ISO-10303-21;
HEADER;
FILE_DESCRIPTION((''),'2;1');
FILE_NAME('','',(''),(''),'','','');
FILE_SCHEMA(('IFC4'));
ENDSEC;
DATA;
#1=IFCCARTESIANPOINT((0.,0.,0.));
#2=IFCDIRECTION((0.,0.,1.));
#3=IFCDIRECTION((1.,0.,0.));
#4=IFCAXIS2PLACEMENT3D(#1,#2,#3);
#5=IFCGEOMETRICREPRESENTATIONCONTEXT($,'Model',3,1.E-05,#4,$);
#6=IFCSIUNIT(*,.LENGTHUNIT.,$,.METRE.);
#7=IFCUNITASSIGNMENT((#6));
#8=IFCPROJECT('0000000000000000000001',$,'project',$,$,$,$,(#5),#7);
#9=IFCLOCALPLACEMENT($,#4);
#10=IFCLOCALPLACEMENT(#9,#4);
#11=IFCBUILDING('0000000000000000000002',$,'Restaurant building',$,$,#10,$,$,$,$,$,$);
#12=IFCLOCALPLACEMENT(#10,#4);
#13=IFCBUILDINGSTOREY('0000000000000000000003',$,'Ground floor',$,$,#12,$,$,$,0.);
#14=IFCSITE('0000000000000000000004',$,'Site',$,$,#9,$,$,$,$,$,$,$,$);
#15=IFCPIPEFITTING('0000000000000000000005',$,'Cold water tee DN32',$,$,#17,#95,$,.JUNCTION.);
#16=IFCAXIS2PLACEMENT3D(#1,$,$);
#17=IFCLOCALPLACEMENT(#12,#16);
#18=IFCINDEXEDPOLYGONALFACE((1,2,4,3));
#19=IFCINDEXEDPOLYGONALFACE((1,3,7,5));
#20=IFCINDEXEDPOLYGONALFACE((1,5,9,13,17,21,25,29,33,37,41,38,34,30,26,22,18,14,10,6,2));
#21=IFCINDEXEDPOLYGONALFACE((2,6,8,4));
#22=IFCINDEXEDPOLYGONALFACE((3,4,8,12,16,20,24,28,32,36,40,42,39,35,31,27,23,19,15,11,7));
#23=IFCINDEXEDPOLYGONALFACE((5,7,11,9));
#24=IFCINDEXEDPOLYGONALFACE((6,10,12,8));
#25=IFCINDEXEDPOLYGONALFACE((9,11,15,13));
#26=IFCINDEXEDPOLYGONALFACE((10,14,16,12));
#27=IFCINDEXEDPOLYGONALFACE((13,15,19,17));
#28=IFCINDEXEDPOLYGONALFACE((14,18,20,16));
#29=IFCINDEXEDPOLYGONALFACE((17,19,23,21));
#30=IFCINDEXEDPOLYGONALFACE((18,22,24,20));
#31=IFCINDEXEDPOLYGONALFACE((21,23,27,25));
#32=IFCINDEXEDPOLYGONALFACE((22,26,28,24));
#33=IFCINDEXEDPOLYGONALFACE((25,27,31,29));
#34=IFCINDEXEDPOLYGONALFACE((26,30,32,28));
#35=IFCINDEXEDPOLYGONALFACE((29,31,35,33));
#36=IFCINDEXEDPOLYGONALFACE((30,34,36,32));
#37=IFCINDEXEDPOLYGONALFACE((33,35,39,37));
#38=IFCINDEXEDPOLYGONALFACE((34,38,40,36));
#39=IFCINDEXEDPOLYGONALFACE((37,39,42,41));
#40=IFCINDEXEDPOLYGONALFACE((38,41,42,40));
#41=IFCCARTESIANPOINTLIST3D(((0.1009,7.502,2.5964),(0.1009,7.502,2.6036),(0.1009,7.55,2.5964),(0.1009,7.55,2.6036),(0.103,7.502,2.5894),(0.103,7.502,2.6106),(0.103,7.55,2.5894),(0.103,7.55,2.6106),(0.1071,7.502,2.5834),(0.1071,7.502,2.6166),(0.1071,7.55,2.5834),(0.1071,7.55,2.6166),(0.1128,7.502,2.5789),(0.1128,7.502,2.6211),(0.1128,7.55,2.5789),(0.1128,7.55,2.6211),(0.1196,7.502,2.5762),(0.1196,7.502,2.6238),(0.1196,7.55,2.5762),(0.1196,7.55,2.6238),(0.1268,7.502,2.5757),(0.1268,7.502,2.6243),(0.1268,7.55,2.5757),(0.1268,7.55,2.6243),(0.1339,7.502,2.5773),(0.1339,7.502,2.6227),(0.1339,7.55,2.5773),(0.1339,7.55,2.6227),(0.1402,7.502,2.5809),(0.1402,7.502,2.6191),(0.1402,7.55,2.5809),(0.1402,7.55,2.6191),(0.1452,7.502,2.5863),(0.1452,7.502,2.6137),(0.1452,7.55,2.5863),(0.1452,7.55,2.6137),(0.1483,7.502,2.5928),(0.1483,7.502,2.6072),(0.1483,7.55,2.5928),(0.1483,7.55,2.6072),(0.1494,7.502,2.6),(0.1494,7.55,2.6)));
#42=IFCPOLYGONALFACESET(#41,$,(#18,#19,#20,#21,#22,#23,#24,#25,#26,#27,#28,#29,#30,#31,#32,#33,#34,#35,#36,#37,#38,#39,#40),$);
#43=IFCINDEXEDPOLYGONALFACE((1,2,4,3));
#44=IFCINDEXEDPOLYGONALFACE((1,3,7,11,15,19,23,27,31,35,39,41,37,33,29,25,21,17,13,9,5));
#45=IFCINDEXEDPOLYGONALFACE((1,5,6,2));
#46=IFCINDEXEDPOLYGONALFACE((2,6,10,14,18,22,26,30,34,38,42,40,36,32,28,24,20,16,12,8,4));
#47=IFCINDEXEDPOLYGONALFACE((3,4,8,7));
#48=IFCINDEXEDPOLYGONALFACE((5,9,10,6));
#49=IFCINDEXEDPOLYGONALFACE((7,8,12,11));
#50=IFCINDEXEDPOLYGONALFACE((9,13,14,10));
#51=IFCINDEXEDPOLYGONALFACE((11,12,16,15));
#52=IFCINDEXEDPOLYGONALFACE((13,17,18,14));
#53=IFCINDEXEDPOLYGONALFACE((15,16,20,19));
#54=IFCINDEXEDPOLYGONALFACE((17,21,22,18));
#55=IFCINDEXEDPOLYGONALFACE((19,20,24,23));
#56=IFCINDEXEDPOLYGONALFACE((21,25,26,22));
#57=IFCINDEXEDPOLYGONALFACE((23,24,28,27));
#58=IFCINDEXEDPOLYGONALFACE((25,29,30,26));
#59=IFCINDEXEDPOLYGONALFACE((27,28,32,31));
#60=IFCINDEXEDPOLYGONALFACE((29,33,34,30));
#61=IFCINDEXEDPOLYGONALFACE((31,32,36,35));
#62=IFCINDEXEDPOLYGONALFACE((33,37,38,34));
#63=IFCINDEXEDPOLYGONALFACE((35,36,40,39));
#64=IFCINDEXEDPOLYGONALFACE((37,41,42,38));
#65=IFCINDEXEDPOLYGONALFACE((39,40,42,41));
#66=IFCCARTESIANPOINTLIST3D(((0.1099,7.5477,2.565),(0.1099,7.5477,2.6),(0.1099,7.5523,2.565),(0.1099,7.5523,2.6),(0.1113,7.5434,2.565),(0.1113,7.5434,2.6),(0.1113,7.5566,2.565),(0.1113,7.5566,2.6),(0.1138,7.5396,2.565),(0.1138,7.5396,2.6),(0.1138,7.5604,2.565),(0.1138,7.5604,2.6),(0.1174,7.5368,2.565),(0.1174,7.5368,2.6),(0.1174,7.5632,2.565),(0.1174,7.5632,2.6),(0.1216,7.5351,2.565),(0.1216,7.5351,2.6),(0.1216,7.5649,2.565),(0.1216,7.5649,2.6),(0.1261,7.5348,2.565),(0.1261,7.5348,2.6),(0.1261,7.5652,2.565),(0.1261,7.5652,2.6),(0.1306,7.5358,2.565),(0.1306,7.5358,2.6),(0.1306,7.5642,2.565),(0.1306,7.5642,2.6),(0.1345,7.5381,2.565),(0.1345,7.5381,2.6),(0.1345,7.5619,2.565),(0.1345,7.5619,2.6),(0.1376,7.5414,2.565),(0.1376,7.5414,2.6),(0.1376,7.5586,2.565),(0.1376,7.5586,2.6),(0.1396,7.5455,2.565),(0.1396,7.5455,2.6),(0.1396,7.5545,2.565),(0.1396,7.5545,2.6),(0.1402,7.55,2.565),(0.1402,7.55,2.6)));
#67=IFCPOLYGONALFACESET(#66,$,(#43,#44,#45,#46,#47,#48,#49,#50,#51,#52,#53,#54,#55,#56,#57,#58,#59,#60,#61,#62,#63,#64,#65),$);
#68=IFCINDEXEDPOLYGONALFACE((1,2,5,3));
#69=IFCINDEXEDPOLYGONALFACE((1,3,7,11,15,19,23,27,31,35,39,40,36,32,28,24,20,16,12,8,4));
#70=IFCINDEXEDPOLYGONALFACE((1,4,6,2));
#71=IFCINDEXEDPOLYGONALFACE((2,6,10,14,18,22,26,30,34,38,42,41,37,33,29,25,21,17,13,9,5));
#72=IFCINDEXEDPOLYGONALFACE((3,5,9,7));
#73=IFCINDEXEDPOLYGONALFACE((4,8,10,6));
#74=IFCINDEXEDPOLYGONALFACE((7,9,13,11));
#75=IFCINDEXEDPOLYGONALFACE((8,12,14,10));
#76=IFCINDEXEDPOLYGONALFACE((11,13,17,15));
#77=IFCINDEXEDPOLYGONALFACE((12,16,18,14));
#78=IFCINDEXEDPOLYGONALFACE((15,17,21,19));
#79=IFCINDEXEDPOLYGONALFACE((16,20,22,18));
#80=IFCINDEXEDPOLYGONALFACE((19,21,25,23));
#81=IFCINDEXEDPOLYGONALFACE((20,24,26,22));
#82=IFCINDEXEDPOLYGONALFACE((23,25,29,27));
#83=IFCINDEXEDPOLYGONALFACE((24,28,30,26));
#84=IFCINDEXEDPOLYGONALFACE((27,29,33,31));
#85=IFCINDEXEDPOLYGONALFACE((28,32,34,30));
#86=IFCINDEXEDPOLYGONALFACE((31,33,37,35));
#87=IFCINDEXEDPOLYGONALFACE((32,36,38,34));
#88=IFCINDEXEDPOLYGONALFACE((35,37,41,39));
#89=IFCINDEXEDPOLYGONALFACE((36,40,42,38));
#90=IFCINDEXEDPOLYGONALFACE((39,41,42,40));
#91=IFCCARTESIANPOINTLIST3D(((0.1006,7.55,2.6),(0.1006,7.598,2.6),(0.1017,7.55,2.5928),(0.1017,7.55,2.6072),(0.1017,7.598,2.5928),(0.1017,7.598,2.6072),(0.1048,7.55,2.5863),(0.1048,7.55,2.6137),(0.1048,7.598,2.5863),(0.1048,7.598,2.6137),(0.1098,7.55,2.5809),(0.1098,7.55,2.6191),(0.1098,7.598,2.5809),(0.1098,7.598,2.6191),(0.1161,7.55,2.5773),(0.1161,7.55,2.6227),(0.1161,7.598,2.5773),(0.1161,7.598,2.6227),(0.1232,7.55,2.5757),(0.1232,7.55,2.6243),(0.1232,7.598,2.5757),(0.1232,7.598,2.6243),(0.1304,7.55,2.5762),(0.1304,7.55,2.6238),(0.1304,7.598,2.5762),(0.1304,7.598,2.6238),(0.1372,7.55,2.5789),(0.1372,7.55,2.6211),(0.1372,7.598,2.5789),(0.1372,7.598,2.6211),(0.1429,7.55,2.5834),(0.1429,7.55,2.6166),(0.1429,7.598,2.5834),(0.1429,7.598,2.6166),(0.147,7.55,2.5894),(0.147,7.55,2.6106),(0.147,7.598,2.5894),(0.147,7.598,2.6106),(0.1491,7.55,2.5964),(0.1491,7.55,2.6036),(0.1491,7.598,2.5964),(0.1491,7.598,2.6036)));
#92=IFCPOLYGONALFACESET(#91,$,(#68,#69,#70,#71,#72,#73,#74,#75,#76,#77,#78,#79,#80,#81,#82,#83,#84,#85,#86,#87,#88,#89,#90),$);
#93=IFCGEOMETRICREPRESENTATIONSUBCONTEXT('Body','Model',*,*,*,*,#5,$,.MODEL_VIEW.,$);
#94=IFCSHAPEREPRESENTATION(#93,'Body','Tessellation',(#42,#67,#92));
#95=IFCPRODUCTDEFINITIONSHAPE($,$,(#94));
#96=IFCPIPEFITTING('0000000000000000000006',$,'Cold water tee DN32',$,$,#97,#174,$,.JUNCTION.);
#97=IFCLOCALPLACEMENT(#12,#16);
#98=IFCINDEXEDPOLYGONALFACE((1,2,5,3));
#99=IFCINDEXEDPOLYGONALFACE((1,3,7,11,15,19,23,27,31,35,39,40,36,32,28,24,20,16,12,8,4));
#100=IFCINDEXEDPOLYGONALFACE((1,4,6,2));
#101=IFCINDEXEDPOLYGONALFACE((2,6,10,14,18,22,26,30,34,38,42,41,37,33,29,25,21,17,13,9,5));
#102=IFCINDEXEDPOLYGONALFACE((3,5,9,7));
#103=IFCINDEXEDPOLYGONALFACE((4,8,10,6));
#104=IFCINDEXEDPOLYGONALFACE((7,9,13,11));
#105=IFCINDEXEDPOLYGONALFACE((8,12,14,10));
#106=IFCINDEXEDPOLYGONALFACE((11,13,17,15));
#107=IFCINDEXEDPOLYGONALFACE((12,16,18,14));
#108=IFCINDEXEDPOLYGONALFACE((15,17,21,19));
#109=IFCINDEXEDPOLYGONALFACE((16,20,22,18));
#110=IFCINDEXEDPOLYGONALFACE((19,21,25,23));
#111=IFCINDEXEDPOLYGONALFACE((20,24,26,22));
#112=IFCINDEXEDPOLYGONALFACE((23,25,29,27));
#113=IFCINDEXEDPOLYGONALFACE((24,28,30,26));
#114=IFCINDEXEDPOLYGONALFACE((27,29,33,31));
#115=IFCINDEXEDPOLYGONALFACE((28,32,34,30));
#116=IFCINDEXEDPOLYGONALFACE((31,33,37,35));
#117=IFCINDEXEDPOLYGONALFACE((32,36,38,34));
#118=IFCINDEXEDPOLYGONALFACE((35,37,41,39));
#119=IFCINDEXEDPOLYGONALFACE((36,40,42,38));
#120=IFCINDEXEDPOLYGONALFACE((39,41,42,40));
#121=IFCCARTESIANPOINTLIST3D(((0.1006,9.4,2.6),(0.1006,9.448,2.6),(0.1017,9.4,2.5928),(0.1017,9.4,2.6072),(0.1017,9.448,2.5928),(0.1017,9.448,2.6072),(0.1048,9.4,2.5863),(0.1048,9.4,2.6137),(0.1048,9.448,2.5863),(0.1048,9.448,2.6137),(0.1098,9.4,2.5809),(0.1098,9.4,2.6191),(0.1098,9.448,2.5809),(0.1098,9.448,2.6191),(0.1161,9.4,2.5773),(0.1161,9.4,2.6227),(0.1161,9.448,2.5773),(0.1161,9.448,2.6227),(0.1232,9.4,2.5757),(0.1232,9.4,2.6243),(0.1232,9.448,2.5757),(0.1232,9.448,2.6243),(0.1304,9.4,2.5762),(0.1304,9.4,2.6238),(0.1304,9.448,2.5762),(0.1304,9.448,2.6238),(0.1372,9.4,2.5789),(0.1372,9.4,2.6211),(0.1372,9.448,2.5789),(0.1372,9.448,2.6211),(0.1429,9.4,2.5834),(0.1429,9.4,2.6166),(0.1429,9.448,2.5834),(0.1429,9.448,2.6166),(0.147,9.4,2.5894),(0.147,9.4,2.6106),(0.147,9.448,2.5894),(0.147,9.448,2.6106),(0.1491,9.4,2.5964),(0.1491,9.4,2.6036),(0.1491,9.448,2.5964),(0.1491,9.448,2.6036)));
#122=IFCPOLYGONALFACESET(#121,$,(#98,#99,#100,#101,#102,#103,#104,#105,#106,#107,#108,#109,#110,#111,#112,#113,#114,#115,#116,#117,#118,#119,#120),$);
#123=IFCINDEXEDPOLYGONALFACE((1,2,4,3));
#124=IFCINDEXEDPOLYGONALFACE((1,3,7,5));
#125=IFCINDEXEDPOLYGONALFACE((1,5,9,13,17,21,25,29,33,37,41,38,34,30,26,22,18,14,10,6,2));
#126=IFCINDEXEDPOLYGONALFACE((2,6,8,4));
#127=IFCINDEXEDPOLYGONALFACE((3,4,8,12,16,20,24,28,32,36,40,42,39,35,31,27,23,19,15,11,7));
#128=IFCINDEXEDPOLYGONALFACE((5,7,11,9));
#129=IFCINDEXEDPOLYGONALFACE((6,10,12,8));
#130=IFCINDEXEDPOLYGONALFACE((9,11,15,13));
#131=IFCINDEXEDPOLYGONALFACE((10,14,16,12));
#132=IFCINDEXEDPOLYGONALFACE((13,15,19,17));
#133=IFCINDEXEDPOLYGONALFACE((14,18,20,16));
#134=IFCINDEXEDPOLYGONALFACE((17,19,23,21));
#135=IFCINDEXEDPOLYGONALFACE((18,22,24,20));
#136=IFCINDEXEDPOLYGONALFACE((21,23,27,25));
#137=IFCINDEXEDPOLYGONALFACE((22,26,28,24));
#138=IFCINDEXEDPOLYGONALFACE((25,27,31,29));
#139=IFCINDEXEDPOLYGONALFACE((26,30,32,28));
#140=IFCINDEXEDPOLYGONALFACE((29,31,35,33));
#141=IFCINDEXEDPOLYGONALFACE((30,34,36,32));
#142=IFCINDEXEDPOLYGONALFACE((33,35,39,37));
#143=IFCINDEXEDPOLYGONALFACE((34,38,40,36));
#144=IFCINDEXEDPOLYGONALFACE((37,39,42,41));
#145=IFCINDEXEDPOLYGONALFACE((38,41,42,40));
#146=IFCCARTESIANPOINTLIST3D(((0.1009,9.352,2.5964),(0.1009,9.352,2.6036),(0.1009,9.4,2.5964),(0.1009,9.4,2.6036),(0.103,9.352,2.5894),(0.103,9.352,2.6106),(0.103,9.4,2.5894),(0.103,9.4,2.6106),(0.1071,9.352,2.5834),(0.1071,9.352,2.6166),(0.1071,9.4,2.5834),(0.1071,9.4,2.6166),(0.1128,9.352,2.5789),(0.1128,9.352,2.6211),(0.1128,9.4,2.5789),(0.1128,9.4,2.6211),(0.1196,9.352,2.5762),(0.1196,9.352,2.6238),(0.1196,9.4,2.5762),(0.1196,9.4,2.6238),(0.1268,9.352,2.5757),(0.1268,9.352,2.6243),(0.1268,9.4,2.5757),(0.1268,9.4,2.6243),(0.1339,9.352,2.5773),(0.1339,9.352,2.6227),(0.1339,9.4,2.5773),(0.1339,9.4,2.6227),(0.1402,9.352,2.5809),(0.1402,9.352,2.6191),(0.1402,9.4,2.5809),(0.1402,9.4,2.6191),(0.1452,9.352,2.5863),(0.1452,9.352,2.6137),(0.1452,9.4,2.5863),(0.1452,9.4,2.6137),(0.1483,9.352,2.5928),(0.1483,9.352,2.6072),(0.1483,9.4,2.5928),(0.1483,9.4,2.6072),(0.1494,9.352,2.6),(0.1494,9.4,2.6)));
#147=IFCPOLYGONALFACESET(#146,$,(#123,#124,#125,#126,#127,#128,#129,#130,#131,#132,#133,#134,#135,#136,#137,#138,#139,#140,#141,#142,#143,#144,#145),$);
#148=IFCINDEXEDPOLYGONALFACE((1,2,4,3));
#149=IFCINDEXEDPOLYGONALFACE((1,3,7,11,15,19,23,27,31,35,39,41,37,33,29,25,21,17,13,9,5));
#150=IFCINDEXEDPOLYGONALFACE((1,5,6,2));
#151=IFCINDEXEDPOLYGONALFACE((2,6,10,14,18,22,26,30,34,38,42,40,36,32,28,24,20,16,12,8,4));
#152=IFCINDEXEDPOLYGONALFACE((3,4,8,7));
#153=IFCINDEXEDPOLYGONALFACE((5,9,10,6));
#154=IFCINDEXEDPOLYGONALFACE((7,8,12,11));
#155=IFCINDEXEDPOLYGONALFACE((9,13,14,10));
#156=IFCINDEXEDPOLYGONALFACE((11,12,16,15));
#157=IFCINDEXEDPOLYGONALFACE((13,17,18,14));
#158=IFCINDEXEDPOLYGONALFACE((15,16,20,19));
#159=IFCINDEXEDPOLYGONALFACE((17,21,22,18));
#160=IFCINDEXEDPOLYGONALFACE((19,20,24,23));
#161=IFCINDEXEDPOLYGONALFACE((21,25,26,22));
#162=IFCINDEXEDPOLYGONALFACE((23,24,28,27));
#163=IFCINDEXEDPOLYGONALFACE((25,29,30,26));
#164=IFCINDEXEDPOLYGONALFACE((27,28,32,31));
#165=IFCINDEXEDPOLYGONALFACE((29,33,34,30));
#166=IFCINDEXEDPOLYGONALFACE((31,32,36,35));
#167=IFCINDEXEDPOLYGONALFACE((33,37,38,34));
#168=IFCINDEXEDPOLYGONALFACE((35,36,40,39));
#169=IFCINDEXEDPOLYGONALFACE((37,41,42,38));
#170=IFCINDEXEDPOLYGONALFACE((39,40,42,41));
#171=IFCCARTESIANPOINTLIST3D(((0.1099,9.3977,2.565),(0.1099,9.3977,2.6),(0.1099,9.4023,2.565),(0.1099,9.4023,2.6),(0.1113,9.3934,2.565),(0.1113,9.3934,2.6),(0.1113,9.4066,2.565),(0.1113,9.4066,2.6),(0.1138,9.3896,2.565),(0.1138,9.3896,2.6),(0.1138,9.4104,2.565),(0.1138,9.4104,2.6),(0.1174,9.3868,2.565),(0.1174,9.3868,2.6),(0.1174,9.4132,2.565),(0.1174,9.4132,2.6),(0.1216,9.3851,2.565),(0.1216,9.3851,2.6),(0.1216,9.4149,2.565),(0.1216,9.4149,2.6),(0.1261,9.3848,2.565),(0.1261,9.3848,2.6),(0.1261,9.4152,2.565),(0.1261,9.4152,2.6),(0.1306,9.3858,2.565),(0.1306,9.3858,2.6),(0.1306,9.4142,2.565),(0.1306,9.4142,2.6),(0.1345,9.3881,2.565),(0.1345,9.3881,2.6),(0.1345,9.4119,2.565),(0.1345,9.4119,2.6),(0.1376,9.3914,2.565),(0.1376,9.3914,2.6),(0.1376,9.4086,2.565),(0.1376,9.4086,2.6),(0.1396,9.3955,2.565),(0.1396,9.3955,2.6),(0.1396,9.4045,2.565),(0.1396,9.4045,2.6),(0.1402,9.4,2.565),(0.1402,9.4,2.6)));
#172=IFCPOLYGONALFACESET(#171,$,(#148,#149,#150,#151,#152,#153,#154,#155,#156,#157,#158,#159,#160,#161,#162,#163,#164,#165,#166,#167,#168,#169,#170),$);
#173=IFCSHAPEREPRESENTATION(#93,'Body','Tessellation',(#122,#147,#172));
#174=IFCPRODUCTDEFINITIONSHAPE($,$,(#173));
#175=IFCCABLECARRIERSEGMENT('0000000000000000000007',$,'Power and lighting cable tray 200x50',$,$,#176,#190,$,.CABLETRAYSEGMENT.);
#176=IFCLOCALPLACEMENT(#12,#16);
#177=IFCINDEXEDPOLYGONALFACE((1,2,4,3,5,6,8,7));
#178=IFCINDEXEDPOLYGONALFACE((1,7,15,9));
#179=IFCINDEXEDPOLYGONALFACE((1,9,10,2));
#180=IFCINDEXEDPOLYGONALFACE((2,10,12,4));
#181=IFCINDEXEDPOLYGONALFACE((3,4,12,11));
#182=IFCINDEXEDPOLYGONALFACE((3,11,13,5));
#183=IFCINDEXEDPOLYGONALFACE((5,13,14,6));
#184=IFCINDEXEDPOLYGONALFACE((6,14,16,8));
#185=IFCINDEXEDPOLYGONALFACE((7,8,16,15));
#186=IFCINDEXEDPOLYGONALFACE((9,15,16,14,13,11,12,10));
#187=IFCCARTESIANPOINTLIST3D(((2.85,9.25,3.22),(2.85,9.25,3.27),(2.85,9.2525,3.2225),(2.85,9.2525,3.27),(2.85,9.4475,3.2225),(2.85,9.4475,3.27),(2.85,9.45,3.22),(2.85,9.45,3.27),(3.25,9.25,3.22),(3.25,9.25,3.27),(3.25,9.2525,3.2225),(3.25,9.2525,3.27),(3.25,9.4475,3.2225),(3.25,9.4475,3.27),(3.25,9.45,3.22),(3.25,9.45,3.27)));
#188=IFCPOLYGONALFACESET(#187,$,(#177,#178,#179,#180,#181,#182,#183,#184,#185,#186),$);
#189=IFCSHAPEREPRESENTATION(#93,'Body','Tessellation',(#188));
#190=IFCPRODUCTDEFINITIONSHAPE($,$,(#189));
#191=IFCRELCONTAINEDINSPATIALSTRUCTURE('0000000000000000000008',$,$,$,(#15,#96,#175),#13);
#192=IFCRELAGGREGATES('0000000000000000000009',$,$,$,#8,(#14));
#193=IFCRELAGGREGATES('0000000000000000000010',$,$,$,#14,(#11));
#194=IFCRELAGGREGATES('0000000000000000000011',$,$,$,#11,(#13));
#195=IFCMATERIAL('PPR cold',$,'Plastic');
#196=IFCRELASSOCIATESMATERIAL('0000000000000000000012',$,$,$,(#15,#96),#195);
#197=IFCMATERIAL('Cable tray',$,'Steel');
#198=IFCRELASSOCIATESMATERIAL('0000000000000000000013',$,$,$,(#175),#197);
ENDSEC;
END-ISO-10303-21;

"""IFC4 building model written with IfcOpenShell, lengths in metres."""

from ifc_helpers import new_model, si_unit, frame, origin_with_axes, origin_2d, place, context, subcontext, project, spatial, polyline, circle, outline, extrude, material, element, save


model = new_model("IFC4")

# Units and contexts
model_context = context("Model", 3, precision=1e-05, world=origin_with_axes())
body_context = subcontext(model_context, "Body", "Model", "MODEL_VIEW")
ifc_project = project(units=[si_unit("LENGTHUNIT", "METRE")], contexts=[model_context])

# Site, building, storey
site_placement = place(None, origin_with_axes())
site = spatial("IfcSite", under=ifc_project, at=site_placement, Name="Site")
building_placement = place(site_placement, origin_with_axes())
building = spatial("IfcBuilding", under=site, at=building_placement, Name="Restaurant building")
storey_placement = place(building_placement, origin_with_axes())
storey = spatial("IfcBuildingStorey", under=building, at=storey_placement, Name="Ground floor", Elevation=0.0)

# Shared definitions
ifc_material_1 = material(Name="PPR cold", Category="Plastic")

# Pipe fittings
pipe_fitting_1_placement = place(storey_placement, frame((0.125, 7.55, 2.6)))
element("IfcPipeFitting", 1, at=pipe_fitting_1_placement, inside=storey, material=ifc_material_1, Name="Cold water tee DN32", PredefinedType="JUNCTION", context=body_context, shape_type="SweptSolid", body=[
    extrude(circle(Radius=0.0244, at=origin_2d()), frame((0.0, 0.0, 0.0), z_axis=(0.0, -1.0, 0.0), x_axis=(1.0, 0.0, 0.0)), (0.0, 0.0, 1.0), 0.048),
    extrude(circle(Radius=0.0152, at=origin_2d()), frame((0.0, 0.0, 0.0), z_axis=(0.0, 0.0, -1.0), x_axis=(1.0, 0.0, 0.0)), (0.0, 0.0, 1.0), 0.035),
    extrude(circle(Radius=0.0244, at=origin_2d()), frame((0.0, 0.0, 0.0), z_axis=(0.0, 1.0, 0.0), x_axis=(-1.0, 0.0, 0.0)), (0.0, 0.0, 1.0), 0.048),
])
pipe_fitting_2_placement = place(storey_placement, frame((0.125, 9.4, 2.6)))
element("IfcPipeFitting", 2, at=pipe_fitting_2_placement, inside=storey, material=ifc_material_1, Name="Cold water tee DN32", PredefinedType="JUNCTION", context=body_context, shape_type="SweptSolid", body=[
    extrude(circle(Radius=0.0244, at=origin_2d()), frame((0.0, 0.0, 0.0), z_axis=(0.0, 1.0, 0.0), x_axis=(-1.0, 0.0, 0.0)), (0.0, 0.0, 1.0), 0.048),
    extrude(circle(Radius=0.0244, at=origin_2d()), frame((0.0, 0.0, 0.0), z_axis=(0.0, -1.0, 0.0), x_axis=(1.0, 0.0, 0.0)), (0.0, 0.0, 1.0), 0.048),
    extrude(circle(Radius=0.0152, at=origin_2d()), frame((0.0, 0.0, 0.0), z_axis=(0.0, 0.0, -1.0), x_axis=(1.0, 0.0, 0.0)), (0.0, 0.0, 1.0), 0.035),
])

# Cable carrier segment
ifc_material_2 = material(Name="Cable tray", Category="Steel")
cable_carrier_segment_1_placement = place(storey_placement, frame((2.85, 9.35, 3.245)))
element("IfcCableCarrierSegment", 3, at=cable_carrier_segment_1_placement, inside=storey, material=ifc_material_2, Name="Power and lighting cable tray 200x50", PredefinedType="CABLETRAYSEGMENT", context=body_context, shape_type="SweptSolid", body=[
    extrude(outline(polyline([(-0.1, -0.025), (0.1, -0.025), (0.1, 0.025), (0.0975, 0.025), (0.0975, -0.0225), (-0.0975, -0.0225), (-0.0975, 0.025), (-0.1, 0.025), (-0.1, -0.025)])), frame((0.0, 0.0, 0.0), z_axis=(1.0, 0.0, 0.0), x_axis=(0.0, 1.0, 0.0)), (0.0, 0.0, 1.0), 0.4),
])

save(model, "model.ifc")
